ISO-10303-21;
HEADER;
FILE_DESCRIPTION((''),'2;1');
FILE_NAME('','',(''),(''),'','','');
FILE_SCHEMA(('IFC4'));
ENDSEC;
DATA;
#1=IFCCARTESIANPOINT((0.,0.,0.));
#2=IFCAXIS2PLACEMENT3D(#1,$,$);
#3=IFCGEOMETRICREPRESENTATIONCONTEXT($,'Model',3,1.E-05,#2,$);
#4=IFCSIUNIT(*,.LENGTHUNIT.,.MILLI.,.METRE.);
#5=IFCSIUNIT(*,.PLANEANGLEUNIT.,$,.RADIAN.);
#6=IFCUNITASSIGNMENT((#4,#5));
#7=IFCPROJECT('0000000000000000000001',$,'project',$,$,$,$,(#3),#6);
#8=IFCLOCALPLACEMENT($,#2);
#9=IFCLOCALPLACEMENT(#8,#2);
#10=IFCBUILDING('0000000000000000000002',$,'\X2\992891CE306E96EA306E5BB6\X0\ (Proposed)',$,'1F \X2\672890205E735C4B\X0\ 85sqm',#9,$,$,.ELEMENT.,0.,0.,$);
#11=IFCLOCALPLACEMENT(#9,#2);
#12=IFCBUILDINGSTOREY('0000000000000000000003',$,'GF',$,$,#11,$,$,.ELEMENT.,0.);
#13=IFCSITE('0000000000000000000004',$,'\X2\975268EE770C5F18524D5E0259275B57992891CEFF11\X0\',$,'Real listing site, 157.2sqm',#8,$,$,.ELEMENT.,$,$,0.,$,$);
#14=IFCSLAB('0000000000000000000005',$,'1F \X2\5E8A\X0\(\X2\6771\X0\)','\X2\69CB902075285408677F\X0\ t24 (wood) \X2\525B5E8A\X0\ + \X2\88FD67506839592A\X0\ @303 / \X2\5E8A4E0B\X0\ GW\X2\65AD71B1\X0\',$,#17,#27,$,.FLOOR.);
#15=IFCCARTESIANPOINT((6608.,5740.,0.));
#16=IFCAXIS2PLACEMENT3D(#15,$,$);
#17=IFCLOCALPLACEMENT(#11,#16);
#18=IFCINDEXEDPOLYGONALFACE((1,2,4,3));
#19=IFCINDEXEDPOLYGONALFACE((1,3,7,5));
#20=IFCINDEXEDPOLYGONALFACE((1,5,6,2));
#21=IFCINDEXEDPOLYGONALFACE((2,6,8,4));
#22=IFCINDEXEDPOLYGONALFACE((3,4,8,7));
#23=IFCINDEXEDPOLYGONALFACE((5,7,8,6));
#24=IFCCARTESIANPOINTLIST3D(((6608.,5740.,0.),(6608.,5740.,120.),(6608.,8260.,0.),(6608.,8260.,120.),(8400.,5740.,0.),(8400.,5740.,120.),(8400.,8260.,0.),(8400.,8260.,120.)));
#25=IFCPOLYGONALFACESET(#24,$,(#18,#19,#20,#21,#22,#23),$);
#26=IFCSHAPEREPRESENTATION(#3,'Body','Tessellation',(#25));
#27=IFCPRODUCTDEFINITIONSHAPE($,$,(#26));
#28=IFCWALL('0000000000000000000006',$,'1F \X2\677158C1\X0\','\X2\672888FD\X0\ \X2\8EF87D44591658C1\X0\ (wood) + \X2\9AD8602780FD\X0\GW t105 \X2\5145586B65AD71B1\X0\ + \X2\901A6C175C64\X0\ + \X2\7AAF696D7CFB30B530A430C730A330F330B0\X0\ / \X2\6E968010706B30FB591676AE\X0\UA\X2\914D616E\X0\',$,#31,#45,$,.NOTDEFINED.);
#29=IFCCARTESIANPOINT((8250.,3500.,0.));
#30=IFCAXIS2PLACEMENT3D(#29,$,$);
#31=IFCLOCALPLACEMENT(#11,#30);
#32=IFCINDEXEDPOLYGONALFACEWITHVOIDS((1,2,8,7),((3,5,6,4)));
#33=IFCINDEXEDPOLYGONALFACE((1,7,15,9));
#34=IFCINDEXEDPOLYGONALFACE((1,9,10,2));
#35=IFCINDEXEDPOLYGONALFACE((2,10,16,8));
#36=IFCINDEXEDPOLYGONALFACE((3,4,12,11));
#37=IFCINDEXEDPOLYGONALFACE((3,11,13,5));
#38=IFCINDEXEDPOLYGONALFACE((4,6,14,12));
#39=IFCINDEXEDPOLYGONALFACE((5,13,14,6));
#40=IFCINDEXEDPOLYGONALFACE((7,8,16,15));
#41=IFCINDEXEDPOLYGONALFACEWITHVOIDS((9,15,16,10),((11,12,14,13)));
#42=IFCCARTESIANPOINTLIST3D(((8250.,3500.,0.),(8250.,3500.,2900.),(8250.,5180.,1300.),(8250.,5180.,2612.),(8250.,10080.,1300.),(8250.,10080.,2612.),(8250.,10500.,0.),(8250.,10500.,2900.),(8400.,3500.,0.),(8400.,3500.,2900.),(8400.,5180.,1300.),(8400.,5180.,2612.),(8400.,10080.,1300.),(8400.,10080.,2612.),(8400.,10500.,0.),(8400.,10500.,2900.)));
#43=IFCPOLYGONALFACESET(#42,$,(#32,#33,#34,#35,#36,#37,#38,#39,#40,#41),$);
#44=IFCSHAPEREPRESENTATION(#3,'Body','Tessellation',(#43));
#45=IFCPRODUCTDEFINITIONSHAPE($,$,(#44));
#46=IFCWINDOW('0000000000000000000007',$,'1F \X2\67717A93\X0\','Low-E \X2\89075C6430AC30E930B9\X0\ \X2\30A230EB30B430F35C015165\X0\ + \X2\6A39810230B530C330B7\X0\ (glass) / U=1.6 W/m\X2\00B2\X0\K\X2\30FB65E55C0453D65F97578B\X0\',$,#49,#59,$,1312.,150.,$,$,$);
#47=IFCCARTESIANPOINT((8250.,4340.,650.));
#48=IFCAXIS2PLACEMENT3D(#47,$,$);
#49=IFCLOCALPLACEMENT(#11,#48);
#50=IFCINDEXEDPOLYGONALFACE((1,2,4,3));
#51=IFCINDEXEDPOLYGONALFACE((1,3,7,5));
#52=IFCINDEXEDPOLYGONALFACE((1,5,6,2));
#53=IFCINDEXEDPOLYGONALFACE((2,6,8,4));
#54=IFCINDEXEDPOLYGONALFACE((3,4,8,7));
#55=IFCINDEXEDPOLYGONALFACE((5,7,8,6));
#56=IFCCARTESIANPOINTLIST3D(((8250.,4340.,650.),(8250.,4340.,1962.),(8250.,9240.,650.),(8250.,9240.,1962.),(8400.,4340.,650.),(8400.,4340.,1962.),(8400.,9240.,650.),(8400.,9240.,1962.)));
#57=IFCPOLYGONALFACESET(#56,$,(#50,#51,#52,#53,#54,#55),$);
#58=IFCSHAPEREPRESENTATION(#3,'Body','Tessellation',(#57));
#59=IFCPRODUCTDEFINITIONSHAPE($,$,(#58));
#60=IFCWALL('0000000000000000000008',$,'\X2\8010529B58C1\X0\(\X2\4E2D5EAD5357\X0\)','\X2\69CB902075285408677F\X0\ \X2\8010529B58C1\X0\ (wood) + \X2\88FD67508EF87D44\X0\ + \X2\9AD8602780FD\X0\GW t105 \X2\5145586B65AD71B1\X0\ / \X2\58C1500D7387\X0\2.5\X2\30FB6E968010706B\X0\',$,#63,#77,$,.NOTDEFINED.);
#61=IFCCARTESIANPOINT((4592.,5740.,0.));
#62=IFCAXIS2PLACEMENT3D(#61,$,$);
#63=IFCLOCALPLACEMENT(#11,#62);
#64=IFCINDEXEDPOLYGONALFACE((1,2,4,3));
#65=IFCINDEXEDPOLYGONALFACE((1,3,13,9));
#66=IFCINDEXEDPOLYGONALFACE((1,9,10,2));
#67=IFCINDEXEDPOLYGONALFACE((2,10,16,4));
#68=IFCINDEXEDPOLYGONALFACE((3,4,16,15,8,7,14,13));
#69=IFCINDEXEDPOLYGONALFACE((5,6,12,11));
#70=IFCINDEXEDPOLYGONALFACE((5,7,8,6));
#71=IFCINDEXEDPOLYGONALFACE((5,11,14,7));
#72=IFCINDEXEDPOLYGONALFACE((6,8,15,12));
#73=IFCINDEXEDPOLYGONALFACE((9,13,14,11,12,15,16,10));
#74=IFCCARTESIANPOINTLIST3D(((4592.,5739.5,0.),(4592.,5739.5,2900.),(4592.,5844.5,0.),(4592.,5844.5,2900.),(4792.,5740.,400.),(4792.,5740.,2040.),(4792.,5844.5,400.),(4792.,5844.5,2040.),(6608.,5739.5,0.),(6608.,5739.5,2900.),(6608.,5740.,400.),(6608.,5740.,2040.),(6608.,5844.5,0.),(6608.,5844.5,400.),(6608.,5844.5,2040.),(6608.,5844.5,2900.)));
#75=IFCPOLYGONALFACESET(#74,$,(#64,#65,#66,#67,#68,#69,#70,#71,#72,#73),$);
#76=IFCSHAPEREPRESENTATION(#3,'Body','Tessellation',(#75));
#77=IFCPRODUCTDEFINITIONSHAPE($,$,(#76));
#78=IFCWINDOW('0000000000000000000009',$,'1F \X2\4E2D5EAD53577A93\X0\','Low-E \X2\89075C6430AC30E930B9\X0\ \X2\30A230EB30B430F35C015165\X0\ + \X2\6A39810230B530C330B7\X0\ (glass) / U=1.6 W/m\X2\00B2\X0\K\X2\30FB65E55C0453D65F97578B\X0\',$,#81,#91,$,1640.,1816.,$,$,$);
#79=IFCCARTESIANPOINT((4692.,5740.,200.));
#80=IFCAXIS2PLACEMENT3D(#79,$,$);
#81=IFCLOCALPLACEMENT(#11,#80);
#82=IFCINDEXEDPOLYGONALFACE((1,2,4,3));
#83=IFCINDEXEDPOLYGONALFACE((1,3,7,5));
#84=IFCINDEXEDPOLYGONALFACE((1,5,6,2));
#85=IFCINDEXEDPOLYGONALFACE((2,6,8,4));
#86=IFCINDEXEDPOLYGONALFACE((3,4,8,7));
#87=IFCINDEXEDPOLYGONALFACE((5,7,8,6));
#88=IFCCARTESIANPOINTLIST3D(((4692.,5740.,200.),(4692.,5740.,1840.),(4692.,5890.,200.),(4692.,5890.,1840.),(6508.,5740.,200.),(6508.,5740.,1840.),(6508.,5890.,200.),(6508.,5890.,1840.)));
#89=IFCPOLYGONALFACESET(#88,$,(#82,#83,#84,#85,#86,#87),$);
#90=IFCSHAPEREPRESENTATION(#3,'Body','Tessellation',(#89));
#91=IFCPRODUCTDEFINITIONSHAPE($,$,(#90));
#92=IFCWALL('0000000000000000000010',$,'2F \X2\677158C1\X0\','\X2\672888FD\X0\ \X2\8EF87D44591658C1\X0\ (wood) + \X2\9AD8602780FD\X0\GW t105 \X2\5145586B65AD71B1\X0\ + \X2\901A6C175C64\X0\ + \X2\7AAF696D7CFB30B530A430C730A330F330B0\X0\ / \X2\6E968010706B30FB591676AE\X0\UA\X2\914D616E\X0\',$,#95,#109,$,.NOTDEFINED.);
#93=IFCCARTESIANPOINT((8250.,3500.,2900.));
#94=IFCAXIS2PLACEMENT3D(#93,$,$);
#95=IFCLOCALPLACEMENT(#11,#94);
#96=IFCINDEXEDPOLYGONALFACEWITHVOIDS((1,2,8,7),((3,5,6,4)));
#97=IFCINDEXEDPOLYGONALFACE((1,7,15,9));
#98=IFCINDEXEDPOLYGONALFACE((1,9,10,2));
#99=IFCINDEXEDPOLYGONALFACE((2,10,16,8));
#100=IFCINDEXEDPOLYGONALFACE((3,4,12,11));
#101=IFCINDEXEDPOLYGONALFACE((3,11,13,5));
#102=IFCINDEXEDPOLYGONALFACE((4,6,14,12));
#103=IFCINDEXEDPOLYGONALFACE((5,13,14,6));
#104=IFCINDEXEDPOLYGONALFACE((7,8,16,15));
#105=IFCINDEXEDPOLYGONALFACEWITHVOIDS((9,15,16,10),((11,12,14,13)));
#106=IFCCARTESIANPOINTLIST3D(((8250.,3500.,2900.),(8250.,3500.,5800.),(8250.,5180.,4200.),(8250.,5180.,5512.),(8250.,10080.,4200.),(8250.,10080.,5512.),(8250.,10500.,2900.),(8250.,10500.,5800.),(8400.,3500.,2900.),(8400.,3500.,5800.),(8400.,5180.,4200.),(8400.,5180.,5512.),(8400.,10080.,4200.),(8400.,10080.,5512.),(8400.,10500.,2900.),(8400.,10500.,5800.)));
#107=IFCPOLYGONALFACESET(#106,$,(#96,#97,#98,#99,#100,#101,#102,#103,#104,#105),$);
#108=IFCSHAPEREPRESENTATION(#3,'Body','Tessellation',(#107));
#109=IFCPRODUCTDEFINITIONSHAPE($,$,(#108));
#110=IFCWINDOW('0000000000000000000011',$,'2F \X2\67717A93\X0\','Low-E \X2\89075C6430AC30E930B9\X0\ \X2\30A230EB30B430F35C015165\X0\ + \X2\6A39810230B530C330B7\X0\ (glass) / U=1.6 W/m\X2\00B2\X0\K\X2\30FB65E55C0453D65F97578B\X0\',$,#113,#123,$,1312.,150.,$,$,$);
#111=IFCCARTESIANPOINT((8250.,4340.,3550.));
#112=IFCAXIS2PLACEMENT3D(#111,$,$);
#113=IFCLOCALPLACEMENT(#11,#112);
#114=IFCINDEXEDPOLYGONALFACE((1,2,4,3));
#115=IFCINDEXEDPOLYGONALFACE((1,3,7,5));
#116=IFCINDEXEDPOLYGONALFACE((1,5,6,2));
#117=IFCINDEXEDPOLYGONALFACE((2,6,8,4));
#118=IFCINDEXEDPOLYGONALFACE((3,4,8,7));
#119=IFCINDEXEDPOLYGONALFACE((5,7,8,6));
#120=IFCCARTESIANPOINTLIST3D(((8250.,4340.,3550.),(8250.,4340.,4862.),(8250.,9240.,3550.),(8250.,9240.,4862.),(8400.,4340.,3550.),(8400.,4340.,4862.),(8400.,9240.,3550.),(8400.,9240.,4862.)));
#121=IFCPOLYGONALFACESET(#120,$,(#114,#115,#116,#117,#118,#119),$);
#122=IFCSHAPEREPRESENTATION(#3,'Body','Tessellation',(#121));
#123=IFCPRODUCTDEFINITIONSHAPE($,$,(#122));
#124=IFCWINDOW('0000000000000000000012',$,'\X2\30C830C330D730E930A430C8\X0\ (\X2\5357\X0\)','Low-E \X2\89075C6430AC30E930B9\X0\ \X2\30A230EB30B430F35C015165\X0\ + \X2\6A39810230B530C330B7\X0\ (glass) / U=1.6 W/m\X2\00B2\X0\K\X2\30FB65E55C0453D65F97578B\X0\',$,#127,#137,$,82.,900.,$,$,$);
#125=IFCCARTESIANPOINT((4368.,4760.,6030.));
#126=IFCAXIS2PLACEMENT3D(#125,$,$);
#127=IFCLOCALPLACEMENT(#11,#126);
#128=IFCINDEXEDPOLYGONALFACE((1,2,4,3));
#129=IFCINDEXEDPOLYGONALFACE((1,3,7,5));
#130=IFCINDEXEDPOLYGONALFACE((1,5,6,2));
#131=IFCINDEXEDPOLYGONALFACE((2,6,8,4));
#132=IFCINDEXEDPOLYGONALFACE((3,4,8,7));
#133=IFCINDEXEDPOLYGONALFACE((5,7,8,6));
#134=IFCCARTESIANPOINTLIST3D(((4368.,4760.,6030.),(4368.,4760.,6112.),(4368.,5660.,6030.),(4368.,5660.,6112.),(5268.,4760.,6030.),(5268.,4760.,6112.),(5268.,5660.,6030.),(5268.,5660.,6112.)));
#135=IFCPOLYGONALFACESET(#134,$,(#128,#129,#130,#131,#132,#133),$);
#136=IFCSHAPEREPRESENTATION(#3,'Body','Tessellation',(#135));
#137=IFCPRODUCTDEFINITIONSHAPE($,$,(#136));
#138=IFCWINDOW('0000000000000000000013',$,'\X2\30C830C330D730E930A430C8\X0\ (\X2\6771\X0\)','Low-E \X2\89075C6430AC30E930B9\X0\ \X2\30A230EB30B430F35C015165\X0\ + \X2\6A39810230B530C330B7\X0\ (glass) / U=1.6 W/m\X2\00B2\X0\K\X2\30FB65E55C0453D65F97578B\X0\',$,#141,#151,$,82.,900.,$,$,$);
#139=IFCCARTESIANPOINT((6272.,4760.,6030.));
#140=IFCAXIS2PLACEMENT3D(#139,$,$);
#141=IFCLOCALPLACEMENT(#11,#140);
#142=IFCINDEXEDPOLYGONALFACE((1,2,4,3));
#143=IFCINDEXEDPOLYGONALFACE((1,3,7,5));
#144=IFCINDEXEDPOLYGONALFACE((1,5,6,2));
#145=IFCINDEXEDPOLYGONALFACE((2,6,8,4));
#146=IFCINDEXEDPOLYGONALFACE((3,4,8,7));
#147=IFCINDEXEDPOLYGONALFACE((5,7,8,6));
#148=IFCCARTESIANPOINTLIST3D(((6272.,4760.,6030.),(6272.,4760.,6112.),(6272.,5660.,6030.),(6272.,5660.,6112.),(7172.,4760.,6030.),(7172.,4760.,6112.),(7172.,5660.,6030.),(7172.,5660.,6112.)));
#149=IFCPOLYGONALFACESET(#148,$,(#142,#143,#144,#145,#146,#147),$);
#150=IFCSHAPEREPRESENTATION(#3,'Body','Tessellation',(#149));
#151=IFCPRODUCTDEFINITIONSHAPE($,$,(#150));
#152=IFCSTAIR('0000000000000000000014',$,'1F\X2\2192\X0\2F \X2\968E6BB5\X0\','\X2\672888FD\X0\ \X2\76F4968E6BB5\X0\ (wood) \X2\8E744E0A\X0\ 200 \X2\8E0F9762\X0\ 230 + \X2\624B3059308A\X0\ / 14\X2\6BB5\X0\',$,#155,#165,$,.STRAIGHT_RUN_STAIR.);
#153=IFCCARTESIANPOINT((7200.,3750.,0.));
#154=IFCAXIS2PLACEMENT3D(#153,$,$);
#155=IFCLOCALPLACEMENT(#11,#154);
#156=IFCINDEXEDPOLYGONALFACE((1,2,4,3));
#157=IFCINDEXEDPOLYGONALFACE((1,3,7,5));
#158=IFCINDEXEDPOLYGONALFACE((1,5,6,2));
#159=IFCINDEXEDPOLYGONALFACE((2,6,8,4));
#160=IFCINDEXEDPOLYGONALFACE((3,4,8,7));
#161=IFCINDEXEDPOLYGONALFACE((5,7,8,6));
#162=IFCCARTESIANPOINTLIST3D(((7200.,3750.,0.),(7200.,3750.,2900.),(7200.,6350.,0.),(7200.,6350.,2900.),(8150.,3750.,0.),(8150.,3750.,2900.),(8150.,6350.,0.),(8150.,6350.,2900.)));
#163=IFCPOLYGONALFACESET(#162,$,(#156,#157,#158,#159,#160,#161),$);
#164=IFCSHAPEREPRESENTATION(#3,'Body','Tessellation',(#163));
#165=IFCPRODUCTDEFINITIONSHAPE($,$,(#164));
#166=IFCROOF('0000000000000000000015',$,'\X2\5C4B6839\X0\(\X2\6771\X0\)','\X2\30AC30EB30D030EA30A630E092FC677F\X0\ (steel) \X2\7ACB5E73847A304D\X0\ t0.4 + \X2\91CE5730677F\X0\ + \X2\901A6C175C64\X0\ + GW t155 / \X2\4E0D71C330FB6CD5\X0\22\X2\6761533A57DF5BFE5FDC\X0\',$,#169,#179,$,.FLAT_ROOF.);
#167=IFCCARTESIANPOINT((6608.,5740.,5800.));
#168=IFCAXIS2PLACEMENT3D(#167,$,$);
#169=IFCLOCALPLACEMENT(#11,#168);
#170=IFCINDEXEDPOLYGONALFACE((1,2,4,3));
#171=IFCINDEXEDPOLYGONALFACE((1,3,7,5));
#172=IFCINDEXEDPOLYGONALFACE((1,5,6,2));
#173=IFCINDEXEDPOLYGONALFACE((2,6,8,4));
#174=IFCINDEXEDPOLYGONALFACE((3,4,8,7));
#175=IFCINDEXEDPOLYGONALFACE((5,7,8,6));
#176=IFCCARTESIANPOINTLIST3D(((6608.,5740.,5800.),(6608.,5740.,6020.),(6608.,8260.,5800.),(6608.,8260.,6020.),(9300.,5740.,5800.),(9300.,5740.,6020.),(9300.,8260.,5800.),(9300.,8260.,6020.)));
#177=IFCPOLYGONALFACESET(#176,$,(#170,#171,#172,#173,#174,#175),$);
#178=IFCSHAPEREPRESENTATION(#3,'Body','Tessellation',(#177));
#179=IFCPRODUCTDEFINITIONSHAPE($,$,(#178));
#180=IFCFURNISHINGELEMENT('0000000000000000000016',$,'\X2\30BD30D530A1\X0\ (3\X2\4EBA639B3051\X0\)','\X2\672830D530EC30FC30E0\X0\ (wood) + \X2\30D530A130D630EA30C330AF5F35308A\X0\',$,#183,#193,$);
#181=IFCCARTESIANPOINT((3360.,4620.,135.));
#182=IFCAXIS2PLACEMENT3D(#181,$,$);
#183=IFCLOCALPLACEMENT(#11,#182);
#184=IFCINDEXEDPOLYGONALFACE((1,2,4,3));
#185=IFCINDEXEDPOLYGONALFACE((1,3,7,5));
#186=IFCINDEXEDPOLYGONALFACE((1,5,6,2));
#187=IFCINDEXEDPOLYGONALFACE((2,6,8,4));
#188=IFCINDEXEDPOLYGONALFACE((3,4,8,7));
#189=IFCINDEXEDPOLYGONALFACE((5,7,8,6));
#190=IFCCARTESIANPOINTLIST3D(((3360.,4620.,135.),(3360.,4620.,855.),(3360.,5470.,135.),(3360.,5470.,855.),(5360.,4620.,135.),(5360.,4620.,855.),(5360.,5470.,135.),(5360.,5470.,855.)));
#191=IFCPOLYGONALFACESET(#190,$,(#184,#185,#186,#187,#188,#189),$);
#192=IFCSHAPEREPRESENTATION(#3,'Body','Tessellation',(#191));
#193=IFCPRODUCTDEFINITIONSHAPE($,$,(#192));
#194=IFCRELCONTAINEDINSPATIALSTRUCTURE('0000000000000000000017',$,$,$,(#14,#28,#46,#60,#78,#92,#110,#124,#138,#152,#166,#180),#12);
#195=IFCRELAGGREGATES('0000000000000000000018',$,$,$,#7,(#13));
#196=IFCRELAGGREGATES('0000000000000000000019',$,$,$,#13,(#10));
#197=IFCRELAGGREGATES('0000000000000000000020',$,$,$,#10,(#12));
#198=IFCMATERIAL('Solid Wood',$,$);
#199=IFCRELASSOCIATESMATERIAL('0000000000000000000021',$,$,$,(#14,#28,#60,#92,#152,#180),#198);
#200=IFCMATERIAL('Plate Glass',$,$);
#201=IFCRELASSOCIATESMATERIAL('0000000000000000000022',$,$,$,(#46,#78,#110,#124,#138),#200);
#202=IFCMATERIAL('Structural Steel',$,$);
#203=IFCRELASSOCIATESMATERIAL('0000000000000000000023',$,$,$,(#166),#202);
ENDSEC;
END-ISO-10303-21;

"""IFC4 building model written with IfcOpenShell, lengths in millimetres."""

from ifc_helpers import new_model, si_unit, frame, frame_2d, origin, place, context, project, spatial, rectangle, extrude, material, element, fill, save


model = new_model("IFC4")

# Units and contexts
model_context = context("Model", 3, precision=1e-05, world=origin())
ifc_project = project(units=[si_unit("LENGTHUNIT", "METRE", prefix="MILLI"), si_unit("PLANEANGLEUNIT", "RADIAN")], contexts=[model_context])

# Site, building, storey
site_placement = place(None, origin())
site = spatial("IfcSite", under=ifc_project, at=site_placement, Name="青森県弘前市大字館野１", ObjectType="Real listing site, 157.2sqm", CompositionType="ELEMENT", RefElevation=0.0)
building_placement = place(site_placement, origin())
building = spatial("IfcBuilding", under=site, at=building_placement, Name="館野の雪の家 (Proposed)", ObjectType="1F 木造平屋 85sqm", CompositionType="ELEMENT", ElevationOfRefHeight=0.0, ElevationOfTerrain=0.0)
storey_placement = place(building_placement, origin())
storey = spatial("IfcBuildingStorey", under=building, at=storey_placement, Name="GF", CompositionType="ELEMENT", Elevation=0.0)

# Slab
ifc_material_1 = material(Name="Solid Wood")
slab_placement = place(storey_placement, frame((6608.0, 5740.0, 0.0)))
element("IfcSlab", 1, at=slab_placement, inside=storey, material=ifc_material_1, Name="1F 床(東)", Description="構造用合板 t24 (wood) 剛床 + 製材根太 @303 / 床下 GW断熱", PredefinedType="FLOOR", context=model_context, shape_type="SweptSolid", body=[
    extrude(rectangle(XDim=1792.0, YDim=2520.0, at=frame_2d((896.0, 1260.0))), frame((6608.0, 5740.0, 0.0)), (0.0, 0.0, 1.0), 120.0),
])

# Walls, openings, windows
wall_1_placement = place(storey_placement, frame((8250.0, 3500.0, 0.0)))
wall_1 = element("IfcWall", 2, at=wall_1_placement, inside=storey, material=ifc_material_1, Name="1F 東壁", Description="木製 軸組外壁 (wood) + 高性能GW t105 充填断熱 + 通気層 + 窯業系サイディング / 準耐火・外皮UA配慮", PredefinedType="NOTDEFINED", context=model_context, shape_type="SweptSolid", body=[
    extrude(rectangle(XDim=150.0, YDim=7000.0, at=frame_2d((75.0, 3500.0))), frame((8250.0, 3500.0, 0.0)), (0.0, 0.0, 1.0), 2900.0),
])
opening_1_placement = place(storey_placement, frame((8250.0, 4340.0, 650.0)))
opening_1 = element("IfcOpeningElement", 3, at=opening_1_placement, cuts=wall_1, PredefinedType="NOTDEFINED", context=model_context, shape_type="SweptSolid", body=[
    extrude(rectangle(XDim=150.0, YDim=4900.0, at=frame_2d((75.0, 2450.0))), frame((8250.0, 4340.0, 650.0)), (0.0, 0.0, 1.0), 1312.0),
])
ifc_material_2 = material(Name="Plate Glass")
window_1_placement = place(storey_placement, frame((8250.0, 4340.0, 650.0)))
window_1 = element("IfcWindow", 4, at=window_1_placement, inside=storey, material=ifc_material_2, Name="1F 東窓", Description="Low-E 複層ガラス アルゴン封入 + 樹脂サッシ (glass) / U=1.6 W/m²K・日射取得型", OverallHeight=1312.0, OverallWidth=150.0, context=model_context, shape_type="SweptSolid", body=[
    extrude(rectangle(XDim=150.0, YDim=4900.0, at=frame_2d((75.0, 2450.0))), frame((8250.0, 4340.0, 650.0)), (0.0, 0.0, 1.0), 1312.0),
])
fill(opening_1, window_1)
wall_2_placement = place(storey_placement, frame((4592.0, 5740.0, 0.0)))
wall_2 = element("IfcWall", 5, at=wall_2_placement, inside=storey, material=ifc_material_1, Name="耐力壁(中庭南)", Description="構造用合板 耐力壁 (wood) + 製材軸組 + 高性能GW t105 充填断熱 / 壁倍率2.5・準耐火", PredefinedType="NOTDEFINED", context=model_context, shape_type="SweptSolid", body=[
    extrude(rectangle(XDim=2016.0, YDim=105.0, at=frame_2d((1008.0, 52.0))), frame((4592.0, 5740.0, 0.0)), (0.0, 0.0, 1.0), 2900.0),
])
opening_2_placement = place(storey_placement, frame((4692.0, 5740.0, 200.0)))
opening_2 = element("IfcOpeningElement", 6, at=opening_2_placement, cuts=wall_2, PredefinedType="NOTDEFINED", context=model_context, shape_type="SweptSolid", body=[
    extrude(rectangle(XDim=1816.0, YDim=150.0, at=frame_2d((908.0, 75.0))), frame((4692.0, 5740.0, 200.0)), (0.0, 0.0, 1.0), 1640.0),
])
window_2_placement = place(storey_placement, frame((4692.0, 5740.0, 200.0)))
window_2 = element("IfcWindow", 7, at=window_2_placement, inside=storey, material=ifc_material_2, Name="1F 中庭南窓", Description="Low-E 複層ガラス アルゴン封入 + 樹脂サッシ (glass) / U=1.6 W/m²K・日射取得型", OverallHeight=1640.0, OverallWidth=1816.0, context=model_context, shape_type="SweptSolid", body=[
    extrude(rectangle(XDim=1816.0, YDim=150.0, at=frame_2d((908.0, 75.0))), frame((4692.0, 5740.0, 200.0)), (0.0, 0.0, 1.0), 1640.0),
])
fill(opening_2, window_2)

# Wall, opening, window
wall_3_placement = place(storey_placement, frame((8250.0, 3500.0, 2900.0)))
wall_3 = element("IfcWall", 8, at=wall_3_placement, inside=storey, material=ifc_material_1, Name="2F 東壁", Description="木製 軸組外壁 (wood) + 高性能GW t105 充填断熱 + 通気層 + 窯業系サイディング / 準耐火・外皮UA配慮", PredefinedType="NOTDEFINED", context=model_context, shape_type="SweptSolid", body=[
    extrude(rectangle(XDim=150.0, YDim=7000.0, at=frame_2d((75.0, 3500.0))), frame((8250.0, 3500.0, 2900.0)), (0.0, 0.0, 1.0), 2900.0),
])
opening_3_placement = place(storey_placement, frame((8250.0, 4340.0, 3550.0)))
opening_3 = element("IfcOpeningElement", 9, at=opening_3_placement, cuts=wall_3, PredefinedType="NOTDEFINED", context=model_context, shape_type="SweptSolid", body=[
    extrude(rectangle(XDim=150.0, YDim=4900.0, at=frame_2d((75.0, 2450.0))), frame((8250.0, 4340.0, 3550.0)), (0.0, 0.0, 1.0), 1312.0),
])
window_3_placement = place(storey_placement, frame((8250.0, 4340.0, 3550.0)))
window_3 = element("IfcWindow", 10, at=window_3_placement, inside=storey, material=ifc_material_2, Name="2F 東窓", Description="Low-E 複層ガラス アルゴン封入 + 樹脂サッシ (glass) / U=1.6 W/m²K・日射取得型", OverallHeight=1312.0, OverallWidth=150.0, context=model_context, shape_type="SweptSolid", body=[
    extrude(rectangle(XDim=150.0, YDim=4900.0, at=frame_2d((75.0, 2450.0))), frame((8250.0, 4340.0, 3550.0)), (0.0, 0.0, 1.0), 1312.0),
])
fill(opening_3, window_3)

# Windows
window_4_placement = place(storey_placement, frame((4368.0, 4760.0, 6030.0)))
element("IfcWindow", 11, at=window_4_placement, inside=storey, material=ifc_material_2, Name="トップライト (南)", Description="Low-E 複層ガラス アルゴン封入 + 樹脂サッシ (glass) / U=1.6 W/m²K・日射取得型", OverallHeight=82.0, OverallWidth=900.0, context=model_context, shape_type="SweptSolid", body=[
    extrude(rectangle(XDim=900.0, YDim=900.0, at=frame_2d((450.0, 450.0))), frame((4368.0, 4760.0, 6030.0)), (0.0, 0.0, 1.0), 82.0),
])
window_5_placement = place(storey_placement, frame((6272.0, 4760.0, 6030.0)))
element("IfcWindow", 12, at=window_5_placement, inside=storey, material=ifc_material_2, Name="トップライト (東)", Description="Low-E 複層ガラス アルゴン封入 + 樹脂サッシ (glass) / U=1.6 W/m²K・日射取得型", OverallHeight=82.0, OverallWidth=900.0, context=model_context, shape_type="SweptSolid", body=[
    extrude(rectangle(XDim=900.0, YDim=900.0, at=frame_2d((450.0, 450.0))), frame((6272.0, 4760.0, 6030.0)), (0.0, 0.0, 1.0), 82.0),
])

# Stair
stair_placement = place(storey_placement, frame((7200.0, 3750.0, 0.0)))
element("IfcStair", 13, at=stair_placement, inside=storey, material=ifc_material_1, Name="1F→2F 階段", Description="木製 直階段 (wood) 蹴上 200 踏面 230 + 手すり / 14段", PredefinedType="STRAIGHT_RUN_STAIR", context=model_context, shape_type="SweptSolid", body=[
    extrude(rectangle(XDim=950.0, YDim=2600.0, at=frame_2d((475.0, 1300.0))), frame((7200.0, 3750.0, 0.0)), (0.0, 0.0, 1.0), 2900.0),
])

# Roof
ifc_material_3 = material(Name="Structural Steel")
roof_placement = place(storey_placement, frame((6608.0, 5740.0, 5800.0)))
element("IfcRoof", 14, at=roof_placement, inside=storey, material=ifc_material_3, Name="屋根(東)", Description="ガルバリウム鋼板 (steel) 立平葺き t0.4 + 野地板 + 通気層 + GW t155 / 不燃・法22条区域対応", PredefinedType="FLAT_ROOF", context=model_context, shape_type="SweptSolid", body=[
    extrude(rectangle(XDim=2692.0, YDim=2520.0, at=frame_2d((1346.0, 1260.0))), frame((6608.0, 5740.0, 5800.0)), (0.0, 0.0, 1.0), 220.0),
])

# Furnishing element
furnishing_1_placement = place(storey_placement, frame((3360.0, 4620.0, 135.0)))
element("IfcFurnishingElement", 15, at=furnishing_1_placement, inside=storey, material=ifc_material_1, Name="ソファ (3人掛け)", Description="木フレーム (wood) + ファブリック張り", context=model_context, shape_type="SweptSolid", body=[
    extrude(rectangle(XDim=2000.0, YDim=850.0, at=frame_2d((1000.0, 425.0))), frame((3360.0, 4620.0, 135.0)), (0.0, 0.0, 1.0), 720.0),
])

save(model, "model.ifc")
